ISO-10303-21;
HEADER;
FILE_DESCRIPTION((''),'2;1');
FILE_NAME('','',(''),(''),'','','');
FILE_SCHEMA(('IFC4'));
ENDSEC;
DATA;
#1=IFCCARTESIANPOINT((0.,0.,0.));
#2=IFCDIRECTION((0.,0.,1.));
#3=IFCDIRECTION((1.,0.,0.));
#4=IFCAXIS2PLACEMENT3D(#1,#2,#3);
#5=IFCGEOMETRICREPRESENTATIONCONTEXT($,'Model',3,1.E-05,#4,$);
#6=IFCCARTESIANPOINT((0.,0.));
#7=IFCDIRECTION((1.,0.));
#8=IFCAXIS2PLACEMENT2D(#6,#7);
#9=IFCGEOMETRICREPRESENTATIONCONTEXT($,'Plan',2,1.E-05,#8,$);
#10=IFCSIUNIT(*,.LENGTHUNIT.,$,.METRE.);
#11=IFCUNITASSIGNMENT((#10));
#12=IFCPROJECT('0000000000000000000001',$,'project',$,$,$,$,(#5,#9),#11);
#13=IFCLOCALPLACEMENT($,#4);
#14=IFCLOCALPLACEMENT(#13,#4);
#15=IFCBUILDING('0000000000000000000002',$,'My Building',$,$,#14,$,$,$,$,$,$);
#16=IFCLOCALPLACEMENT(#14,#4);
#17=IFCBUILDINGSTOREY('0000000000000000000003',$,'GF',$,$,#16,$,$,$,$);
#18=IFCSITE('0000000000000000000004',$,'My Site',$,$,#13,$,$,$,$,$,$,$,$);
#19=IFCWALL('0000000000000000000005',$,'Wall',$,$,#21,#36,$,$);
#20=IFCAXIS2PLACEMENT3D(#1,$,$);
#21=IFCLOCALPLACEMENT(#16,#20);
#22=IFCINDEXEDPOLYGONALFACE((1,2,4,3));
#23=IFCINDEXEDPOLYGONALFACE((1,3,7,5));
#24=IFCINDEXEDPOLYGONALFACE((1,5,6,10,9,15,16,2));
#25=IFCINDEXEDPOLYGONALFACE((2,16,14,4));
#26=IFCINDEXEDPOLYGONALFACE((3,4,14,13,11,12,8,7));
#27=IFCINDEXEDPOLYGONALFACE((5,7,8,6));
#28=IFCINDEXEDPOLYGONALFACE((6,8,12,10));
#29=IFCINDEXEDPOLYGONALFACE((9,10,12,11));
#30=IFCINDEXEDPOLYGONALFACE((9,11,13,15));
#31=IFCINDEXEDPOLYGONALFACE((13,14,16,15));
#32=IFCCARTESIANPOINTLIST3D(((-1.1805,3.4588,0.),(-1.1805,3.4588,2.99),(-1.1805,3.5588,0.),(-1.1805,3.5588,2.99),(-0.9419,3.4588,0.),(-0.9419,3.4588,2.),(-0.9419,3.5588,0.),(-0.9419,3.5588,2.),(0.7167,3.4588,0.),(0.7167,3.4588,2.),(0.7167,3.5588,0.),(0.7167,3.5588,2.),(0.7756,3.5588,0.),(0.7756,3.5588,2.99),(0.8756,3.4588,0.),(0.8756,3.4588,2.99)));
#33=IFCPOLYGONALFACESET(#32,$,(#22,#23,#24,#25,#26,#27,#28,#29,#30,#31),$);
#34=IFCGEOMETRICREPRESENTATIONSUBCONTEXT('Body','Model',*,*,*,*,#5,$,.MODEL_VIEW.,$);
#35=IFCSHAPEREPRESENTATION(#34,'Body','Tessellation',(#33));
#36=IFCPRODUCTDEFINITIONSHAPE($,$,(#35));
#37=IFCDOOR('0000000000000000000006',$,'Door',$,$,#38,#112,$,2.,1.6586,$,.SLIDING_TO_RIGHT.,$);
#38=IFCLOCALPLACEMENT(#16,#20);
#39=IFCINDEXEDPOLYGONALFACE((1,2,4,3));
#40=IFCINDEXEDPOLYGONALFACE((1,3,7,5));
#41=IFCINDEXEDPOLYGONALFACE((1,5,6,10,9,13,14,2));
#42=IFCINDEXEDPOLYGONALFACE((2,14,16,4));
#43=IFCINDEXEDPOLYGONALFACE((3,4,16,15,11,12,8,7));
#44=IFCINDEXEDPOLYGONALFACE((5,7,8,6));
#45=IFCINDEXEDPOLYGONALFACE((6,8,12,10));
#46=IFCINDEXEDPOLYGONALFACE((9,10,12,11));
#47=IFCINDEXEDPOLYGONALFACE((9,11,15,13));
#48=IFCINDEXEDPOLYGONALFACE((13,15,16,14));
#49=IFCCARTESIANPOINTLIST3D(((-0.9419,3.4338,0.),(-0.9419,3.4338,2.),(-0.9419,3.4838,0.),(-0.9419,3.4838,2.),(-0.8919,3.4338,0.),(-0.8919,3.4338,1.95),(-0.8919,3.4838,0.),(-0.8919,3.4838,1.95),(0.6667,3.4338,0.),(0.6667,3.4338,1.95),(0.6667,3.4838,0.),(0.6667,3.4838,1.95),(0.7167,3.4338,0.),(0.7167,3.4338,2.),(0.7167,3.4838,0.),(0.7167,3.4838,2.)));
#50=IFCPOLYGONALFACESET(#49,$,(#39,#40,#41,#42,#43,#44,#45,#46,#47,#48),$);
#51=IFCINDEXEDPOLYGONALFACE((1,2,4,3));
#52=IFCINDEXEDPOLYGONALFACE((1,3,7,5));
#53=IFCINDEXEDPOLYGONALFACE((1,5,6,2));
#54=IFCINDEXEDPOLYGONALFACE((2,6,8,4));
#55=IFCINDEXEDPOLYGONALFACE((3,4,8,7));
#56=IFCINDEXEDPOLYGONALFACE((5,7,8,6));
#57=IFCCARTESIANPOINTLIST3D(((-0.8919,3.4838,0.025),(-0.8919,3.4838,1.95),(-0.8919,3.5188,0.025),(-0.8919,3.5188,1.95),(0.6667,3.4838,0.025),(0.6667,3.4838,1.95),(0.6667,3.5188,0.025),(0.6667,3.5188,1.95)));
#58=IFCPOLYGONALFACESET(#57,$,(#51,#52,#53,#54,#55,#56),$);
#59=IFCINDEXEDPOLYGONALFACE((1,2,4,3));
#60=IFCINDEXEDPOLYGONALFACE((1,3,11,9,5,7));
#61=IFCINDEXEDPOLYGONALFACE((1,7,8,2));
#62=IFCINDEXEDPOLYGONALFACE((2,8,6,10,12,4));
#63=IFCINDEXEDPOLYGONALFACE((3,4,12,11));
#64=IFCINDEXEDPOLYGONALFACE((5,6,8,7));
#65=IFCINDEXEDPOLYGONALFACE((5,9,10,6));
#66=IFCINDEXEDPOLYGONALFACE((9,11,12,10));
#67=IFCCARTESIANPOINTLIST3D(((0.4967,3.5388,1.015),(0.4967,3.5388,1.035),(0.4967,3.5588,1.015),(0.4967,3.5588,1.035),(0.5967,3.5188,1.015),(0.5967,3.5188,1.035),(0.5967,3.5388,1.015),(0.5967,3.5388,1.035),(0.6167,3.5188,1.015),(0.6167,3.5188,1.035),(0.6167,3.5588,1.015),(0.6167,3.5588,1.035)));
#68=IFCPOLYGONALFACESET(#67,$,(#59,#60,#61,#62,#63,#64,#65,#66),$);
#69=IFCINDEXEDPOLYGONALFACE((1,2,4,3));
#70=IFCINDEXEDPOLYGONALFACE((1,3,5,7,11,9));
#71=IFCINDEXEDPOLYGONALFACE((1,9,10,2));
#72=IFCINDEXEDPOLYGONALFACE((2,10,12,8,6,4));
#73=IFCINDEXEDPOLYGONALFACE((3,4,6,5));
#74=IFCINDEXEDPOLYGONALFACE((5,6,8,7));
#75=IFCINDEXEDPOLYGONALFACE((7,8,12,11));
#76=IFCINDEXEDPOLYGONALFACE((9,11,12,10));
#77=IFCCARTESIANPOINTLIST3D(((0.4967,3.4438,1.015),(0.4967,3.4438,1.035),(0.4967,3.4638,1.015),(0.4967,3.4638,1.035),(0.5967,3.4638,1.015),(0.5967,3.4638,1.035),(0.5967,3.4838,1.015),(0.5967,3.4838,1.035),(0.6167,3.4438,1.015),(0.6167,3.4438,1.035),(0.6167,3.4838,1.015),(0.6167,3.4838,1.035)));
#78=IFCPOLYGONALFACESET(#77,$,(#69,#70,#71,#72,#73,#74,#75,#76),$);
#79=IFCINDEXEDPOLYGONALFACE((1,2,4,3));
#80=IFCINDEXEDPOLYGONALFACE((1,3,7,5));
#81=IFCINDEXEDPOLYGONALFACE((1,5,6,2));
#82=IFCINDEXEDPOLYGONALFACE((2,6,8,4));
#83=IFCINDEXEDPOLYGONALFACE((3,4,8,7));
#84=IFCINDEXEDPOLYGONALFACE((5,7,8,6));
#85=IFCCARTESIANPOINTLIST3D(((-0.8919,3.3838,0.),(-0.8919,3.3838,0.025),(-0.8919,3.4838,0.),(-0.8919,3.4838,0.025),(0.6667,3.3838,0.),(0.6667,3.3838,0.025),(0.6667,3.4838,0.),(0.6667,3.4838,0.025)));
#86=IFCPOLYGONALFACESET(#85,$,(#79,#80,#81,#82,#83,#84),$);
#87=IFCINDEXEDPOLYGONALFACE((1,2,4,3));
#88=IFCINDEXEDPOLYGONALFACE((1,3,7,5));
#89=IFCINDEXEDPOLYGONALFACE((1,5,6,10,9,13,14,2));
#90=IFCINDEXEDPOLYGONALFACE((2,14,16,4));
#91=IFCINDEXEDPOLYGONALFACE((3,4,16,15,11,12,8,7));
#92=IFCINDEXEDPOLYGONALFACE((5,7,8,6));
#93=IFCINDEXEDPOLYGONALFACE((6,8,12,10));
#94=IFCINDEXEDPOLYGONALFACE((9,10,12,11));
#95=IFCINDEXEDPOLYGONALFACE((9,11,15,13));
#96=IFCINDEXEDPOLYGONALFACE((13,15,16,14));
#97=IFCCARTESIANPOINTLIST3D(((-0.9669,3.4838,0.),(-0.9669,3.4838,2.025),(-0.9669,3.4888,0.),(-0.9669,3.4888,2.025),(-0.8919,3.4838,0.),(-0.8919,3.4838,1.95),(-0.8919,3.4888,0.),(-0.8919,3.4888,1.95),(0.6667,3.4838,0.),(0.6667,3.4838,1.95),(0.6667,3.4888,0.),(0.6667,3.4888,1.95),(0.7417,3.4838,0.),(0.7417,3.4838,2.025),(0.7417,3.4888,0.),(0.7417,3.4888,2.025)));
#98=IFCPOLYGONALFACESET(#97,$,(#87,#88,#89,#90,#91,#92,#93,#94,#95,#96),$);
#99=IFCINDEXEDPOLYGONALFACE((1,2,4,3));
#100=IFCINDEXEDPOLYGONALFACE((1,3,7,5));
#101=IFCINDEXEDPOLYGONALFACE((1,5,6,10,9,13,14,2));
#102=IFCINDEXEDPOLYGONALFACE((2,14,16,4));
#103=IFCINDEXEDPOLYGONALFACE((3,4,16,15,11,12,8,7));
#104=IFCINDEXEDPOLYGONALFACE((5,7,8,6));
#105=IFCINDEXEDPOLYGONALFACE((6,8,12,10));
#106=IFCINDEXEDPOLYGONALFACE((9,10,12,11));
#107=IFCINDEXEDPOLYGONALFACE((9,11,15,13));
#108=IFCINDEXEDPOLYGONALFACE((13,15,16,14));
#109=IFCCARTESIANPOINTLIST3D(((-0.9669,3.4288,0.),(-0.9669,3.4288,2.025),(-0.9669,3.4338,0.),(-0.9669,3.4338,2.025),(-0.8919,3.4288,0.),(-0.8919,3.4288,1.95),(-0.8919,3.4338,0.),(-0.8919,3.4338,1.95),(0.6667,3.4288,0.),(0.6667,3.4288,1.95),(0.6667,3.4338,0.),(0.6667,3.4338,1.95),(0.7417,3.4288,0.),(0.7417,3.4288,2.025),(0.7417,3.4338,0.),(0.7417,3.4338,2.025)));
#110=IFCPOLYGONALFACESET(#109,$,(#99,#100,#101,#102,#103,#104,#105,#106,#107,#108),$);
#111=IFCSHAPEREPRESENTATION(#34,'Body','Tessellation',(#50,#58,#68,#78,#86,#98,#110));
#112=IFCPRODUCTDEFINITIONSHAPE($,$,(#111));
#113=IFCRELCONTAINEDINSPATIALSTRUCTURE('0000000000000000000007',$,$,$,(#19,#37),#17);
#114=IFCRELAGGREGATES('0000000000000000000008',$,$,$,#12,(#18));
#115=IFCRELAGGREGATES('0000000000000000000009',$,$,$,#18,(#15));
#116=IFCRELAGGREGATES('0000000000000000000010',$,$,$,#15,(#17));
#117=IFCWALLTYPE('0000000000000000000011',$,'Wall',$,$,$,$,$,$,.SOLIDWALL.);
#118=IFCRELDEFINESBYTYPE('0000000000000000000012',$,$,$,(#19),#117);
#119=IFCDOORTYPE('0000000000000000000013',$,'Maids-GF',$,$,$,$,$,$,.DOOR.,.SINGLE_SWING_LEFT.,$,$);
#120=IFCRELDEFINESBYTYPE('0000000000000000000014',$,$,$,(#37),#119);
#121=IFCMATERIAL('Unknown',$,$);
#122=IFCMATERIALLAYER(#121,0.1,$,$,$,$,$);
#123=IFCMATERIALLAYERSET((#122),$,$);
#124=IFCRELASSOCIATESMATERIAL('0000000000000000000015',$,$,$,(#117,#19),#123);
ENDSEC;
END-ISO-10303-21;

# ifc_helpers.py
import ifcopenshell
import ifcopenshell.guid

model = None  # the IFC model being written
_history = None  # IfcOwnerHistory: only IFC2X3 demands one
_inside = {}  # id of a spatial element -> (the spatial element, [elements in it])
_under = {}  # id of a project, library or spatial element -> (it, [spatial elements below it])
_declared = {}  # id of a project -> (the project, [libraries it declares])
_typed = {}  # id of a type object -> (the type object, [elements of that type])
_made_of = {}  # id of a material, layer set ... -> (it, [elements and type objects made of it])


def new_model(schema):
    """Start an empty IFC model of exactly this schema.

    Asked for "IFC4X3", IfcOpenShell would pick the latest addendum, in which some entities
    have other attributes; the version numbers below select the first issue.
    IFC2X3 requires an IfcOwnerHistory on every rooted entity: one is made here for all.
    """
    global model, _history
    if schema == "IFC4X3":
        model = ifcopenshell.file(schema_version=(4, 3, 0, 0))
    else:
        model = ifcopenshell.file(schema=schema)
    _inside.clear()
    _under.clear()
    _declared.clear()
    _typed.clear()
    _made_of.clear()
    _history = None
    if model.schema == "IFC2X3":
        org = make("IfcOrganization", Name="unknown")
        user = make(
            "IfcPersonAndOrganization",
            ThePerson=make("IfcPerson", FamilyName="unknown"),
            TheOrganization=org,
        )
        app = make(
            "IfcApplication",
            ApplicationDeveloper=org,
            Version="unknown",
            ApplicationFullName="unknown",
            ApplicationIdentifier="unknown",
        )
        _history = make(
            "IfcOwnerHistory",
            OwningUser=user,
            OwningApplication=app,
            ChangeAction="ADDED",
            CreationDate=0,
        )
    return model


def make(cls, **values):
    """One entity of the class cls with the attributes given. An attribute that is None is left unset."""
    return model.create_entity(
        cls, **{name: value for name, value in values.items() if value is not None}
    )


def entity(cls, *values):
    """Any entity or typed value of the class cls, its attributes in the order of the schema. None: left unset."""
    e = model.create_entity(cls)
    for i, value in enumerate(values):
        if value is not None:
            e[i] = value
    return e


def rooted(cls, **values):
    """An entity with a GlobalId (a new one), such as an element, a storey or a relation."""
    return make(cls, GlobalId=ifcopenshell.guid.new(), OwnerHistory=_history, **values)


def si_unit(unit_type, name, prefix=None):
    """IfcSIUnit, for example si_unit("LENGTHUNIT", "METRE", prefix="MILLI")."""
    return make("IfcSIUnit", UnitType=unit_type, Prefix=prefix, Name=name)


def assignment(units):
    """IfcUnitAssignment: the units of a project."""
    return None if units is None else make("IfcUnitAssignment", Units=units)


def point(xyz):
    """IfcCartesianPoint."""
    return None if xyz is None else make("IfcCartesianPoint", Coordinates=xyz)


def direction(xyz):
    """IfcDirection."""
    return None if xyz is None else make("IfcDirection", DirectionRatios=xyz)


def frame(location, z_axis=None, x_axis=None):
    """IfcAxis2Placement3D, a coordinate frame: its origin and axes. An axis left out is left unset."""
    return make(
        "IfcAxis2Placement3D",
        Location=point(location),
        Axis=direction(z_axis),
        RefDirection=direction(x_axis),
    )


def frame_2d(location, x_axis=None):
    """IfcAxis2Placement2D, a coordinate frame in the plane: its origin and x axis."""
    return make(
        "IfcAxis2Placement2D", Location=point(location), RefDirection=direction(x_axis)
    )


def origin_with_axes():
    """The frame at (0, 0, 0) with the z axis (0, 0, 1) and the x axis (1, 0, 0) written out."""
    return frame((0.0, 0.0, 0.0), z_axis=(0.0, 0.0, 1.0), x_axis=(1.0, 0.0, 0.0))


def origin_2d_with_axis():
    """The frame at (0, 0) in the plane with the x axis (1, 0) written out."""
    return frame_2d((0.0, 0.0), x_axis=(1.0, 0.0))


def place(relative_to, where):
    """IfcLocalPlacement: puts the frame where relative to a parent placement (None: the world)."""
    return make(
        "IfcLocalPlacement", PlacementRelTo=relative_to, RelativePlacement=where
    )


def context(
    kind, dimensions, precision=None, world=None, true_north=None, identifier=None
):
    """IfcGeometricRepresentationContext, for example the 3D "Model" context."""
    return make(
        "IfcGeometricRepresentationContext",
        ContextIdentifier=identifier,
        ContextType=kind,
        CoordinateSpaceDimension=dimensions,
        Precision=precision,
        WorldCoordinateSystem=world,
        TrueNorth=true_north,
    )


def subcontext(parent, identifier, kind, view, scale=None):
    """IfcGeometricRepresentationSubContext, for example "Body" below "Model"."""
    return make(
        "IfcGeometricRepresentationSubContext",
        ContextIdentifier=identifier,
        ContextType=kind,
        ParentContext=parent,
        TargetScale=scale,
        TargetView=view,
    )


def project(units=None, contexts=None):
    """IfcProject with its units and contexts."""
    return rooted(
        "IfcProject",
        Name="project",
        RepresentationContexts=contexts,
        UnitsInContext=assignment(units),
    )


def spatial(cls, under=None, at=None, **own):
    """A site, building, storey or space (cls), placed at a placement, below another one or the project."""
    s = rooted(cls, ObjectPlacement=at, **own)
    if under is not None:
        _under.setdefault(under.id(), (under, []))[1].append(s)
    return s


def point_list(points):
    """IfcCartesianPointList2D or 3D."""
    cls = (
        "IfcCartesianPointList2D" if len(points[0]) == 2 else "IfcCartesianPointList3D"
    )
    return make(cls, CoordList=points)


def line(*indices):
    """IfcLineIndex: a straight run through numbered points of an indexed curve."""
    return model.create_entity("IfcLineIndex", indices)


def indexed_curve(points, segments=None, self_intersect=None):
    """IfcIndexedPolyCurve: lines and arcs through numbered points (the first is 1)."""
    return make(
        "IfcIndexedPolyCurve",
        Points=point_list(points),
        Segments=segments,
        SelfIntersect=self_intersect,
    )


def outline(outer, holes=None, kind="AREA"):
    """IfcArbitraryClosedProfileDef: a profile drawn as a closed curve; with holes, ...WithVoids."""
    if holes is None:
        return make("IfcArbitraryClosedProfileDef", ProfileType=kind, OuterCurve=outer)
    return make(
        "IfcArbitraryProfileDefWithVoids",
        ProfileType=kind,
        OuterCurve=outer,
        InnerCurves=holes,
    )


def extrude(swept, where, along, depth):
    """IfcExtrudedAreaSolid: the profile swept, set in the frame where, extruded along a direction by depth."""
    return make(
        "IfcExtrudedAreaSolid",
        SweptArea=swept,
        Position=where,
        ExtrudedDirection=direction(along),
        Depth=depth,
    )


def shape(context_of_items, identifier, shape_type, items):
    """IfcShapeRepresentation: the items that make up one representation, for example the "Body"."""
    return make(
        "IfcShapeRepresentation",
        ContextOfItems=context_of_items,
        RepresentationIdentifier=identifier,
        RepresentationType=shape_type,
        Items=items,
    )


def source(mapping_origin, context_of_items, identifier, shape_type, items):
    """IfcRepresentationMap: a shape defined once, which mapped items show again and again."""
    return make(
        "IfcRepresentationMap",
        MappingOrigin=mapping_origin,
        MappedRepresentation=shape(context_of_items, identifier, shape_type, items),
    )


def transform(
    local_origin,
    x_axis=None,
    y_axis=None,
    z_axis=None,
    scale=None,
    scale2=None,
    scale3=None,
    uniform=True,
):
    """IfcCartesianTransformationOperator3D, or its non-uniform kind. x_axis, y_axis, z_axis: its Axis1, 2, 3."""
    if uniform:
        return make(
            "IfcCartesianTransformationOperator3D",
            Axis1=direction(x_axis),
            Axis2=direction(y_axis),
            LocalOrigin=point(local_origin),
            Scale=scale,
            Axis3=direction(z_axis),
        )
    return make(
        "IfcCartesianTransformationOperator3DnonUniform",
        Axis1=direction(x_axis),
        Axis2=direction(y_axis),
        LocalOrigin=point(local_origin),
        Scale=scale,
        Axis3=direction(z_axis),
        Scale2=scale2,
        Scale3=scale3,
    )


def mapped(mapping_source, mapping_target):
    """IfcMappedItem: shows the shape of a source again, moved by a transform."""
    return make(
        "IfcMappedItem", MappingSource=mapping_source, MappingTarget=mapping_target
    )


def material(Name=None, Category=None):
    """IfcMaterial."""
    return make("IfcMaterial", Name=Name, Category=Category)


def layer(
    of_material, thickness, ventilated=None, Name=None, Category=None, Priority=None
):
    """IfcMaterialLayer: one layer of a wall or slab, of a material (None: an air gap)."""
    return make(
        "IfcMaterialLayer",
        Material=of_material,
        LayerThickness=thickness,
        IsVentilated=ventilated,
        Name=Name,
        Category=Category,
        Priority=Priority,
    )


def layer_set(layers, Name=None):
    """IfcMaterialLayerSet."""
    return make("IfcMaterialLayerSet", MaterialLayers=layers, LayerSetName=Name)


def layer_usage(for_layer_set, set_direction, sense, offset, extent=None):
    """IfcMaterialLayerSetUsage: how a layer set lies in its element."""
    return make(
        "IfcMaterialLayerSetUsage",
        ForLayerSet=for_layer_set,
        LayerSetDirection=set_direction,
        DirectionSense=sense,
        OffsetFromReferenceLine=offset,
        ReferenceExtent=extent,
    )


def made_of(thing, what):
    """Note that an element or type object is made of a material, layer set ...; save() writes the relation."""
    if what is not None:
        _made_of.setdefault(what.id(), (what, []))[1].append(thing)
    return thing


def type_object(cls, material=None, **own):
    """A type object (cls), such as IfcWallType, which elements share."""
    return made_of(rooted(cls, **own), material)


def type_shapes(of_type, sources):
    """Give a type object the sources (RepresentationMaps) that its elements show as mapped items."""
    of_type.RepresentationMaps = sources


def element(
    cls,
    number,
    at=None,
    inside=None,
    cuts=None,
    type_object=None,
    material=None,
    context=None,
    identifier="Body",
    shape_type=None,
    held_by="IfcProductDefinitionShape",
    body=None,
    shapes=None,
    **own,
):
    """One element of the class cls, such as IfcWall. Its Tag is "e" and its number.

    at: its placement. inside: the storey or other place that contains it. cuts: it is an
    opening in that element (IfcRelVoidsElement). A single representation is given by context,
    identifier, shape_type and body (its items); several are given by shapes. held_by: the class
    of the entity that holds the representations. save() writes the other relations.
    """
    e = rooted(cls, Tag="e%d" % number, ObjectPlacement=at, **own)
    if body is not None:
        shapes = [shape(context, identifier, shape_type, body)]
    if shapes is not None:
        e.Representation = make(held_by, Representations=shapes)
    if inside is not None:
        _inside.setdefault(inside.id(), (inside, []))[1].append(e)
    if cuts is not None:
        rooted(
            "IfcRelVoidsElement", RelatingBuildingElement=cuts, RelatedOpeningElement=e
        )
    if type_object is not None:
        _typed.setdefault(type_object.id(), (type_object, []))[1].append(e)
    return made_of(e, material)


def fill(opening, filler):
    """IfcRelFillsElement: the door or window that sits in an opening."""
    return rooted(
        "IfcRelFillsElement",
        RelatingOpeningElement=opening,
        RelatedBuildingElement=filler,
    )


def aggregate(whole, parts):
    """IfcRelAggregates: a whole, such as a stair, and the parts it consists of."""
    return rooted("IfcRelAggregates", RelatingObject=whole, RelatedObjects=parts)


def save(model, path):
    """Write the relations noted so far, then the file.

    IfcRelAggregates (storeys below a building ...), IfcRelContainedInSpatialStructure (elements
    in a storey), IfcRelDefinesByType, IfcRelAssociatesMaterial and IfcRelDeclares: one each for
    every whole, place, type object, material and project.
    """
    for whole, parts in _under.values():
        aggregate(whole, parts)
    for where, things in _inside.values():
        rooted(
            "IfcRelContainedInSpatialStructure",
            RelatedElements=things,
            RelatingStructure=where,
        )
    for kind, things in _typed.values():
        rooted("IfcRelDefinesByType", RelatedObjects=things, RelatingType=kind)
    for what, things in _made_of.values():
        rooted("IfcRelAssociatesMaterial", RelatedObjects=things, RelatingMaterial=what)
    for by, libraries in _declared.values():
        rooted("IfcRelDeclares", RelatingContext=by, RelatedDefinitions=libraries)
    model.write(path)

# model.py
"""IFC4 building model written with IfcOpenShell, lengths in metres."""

from ifc_helpers import new_model, entity, si_unit, frame, origin_with_axes, origin_2d_with_axis, place, context, subcontext, project, spatial, line, indexed_curve, outline, extrude, shape, source, transform, mapped, material, layer, layer_set, layer_usage, type_object, type_shapes, element, fill, save


model = new_model("IFC4")

# Units and contexts
model_context = context("Model", 3, precision=1e-05, world=origin_with_axes())
plan_context = context("Plan", 2, precision=1e-05, world=origin_2d_with_axis())
body_context_1 = subcontext(model_context, "Body", "Model", "MODEL_VIEW")
body_context_2 = subcontext(plan_context, "Body", "Plan", "PLAN_VIEW")
ifc_project = project(units=[si_unit("LENGTHUNIT", "METRE")], contexts=[model_context, plan_context])

# Site, building, storey
site_placement = place(None, origin_with_axes())
site = spatial("IfcSite", under=ifc_project, at=site_placement, Name="My Site")
building_placement = place(site_placement, origin_with_axes())
building = spatial("IfcBuilding", under=site, at=building_placement, Name="My Building")
storey_placement = place(building_placement, origin_with_axes())
storey = spatial("IfcBuildingStorey", under=building, at=storey_placement, Name="GF")

# Shared definitions
ifc_material = material(Name="Unknown")

# Shared definitions
ifc_layer_1 = layer(ifc_material, 0.1)
ifc_layer_set_1 = layer_set([ifc_layer_1])
wall_type = type_object("IfcWallType", Name="Wall", PredefinedType="SOLIDWALL", material=ifc_layer_set_1)

# Wall, opening, door
ifc_layer_usage_1 = layer_usage(ifc_layer_set_1, "AXIS2", "POSITIVE", 0.0)
wall_1_placement = place(storey_placement, frame((0.7756, 3.5588, 0.0), z_axis=(0.0, 0.0, 1.0), x_axis=(-1.0, 0.0, 0.0)))
wall_1 = element("IfcWall", 1, at=wall_1_placement, inside=storey, type_object=wall_type, material=ifc_layer_usage_1, Name="Wall", context=body_context_1, shape_type="SweptSolid", body=[
    extrude(outline(indexed_curve([(0.0, 0.0), (-0.1, 0.1), (1.9562, 0.1), (1.9562, 0.0)], segments=[line(1, 2, 3, 4, 1)])), origin_with_axes(), (0.0, 0.0, 1.0), 2.99),
])
shared_shape_1 = source(origin_with_axes(), body_context_1, "Body", "SweptSolid", [
    extrude(outline(indexed_curve([(0.0, 0.0), (1.6586, 0.0), (1.6586, 2.0), (0.0, 2.0)], segments=[line(1, 2, 3, 4, 1)])), frame((0.0, -0.6, 0.0), z_axis=(0.0, -1.0, 0.0), x_axis=(1.0, 0.0, 0.0)), (0.0, 0.0, -1.0), 1.2),
])
opening_1_placement = place(wall_1_placement, frame((0.0589, 0.075, 0.0), z_axis=(0.0, 0.0, 1.0), x_axis=(1.0, 0.0, 0.0)))
opening_1 = element("IfcOpeningElement", 2, at=opening_1_placement, cuts=wall_1, PredefinedType="OPENING", context=body_context_1, shape_type="MappedRepresentation", body=[
    mapped(shared_shape_1, transform((0.0, 0.0, 0.0), x_axis=(1.0, 0.0, 0.0), y_axis=(0.0, 1.0, 0.0), z_axis=(0.0, 0.0, 1.0), scale=1.0)),
])
door_type_1 = type_object("IfcDoorType", Name="Maids-GF", OperationType="SINGLE_SWING_LEFT", PredefinedType="DOOR")
shared_shape_2 = source(origin_with_axes(), body_context_1, "Body", "SweptSolid", [
    extrude(outline(indexed_curve([(0.0, 0.0), (0.0, 2.0), (1.6586, 2.0), (1.6586, 0.0), (1.6086, 0.0), (1.6086, 1.95), (0.05, 1.95), (0.05, 0.0)], segments=[line(1, 2, 3, 4, 5, 6, 7, 8, 1)])), frame((0.0, 0.0, 0.0), z_axis=(0.0, -1.0, 0.0), x_axis=(1.0, 0.0, 0.0)), (0.0, 0.0, -1.0), 0.05),
    extrude(outline(indexed_curve([(0.0, 0.0), (1.5586, 0.0), (1.5586, 0.035), (0.0, 0.035)], segments=[line(1, 2, 3, 4, 1)])), frame((0.05, -0.035, 0.025), z_axis=(0.0, 0.0, 1.0), x_axis=(1.0, 0.0, 0.0)), (0.0, 0.0, 1.0), 1.925),
    extrude(outline(indexed_curve([(0.0, 0.0), (0.0, -0.04), (0.12, -0.04), (0.12, -0.02), (0.02, -0.02), (0.02, 0.0)], segments=[line(1, 2, 3, 4, 5, 6, 1)])), frame((0.1, -0.035, 1.015), z_axis=(0.0, 0.0, 1.0), x_axis=(1.0, 0.0, 0.0)), (0.0, 0.0, 1.0), 0.02),
    extrude(outline(indexed_curve([(0.0, 0.0), (0.0, 0.04), (0.12, 0.04), (0.12, 0.02), (0.02, 0.02), (0.02, 0.0)], segments=[line(1, 2, 3, 4, 5, 6, 1)])), frame((0.1, 0.0, 1.015), z_axis=(0.0, 0.0, 1.0), x_axis=(1.0, 0.0, 0.0)), (0.0, 0.0, 1.0), 0.02),
    extrude(outline(indexed_curve([(0.0, 0.0), (1.5586, 0.0), (1.5586, 0.1), (0.0, 0.1)], segments=[line(1, 2, 3, 4, 1)])), frame((0.05, 0.0, 0.0), z_axis=(0.0, 0.0, 1.0), x_axis=(1.0, 0.0, 0.0)), (0.0, 0.0, 1.0), 0.025),
    extrude(outline(indexed_curve([(0.0, 0.0), (0.0, 2.025), (1.7086, 2.025), (1.7086, 0.0), (1.6336, 0.0), (1.6336, 1.95), (0.075, 1.95), (0.075, 0.0)], segments=[line(1, 2, 3, 4, 5, 6, 7, 8, 1)])), frame((-0.025, -0.005, 0.0), z_axis=(0.0, -1.0, 0.0), x_axis=(1.0, 0.0, 0.0)), (0.0, 0.0, -1.0), 0.005),
    extrude(outline(indexed_curve([(0.0, 0.0), (0.0, 2.025), (1.7086, 2.025), (1.7086, 0.0), (1.6336, 0.0), (1.6336, 1.95), (0.075, 1.95), (0.075, 0.0)], segments=[line(1, 2, 3, 4, 5, 6, 7, 8, 1)])), frame((-0.025, 0.05, 0.0), z_axis=(0.0, -1.0, 0.0), x_axis=(1.0, 0.0, 0.0)), (0.0, 0.0, -1.0), 0.005),
])
shared_shape_3 = source(origin_with_axes(), body_context_2, "Body", "Curve2D", [
    entity("IfcIndexedPolyCurve", entity("IfcCartesianPointList2D", [[0.0, 0.0], [0.05, 0.0], [0.05, 0.05], [0.0, 0.05]]), [entity("IfcLineIndex", [1, 2, 3, 4, 1])]),
    entity("IfcIndexedPolyCurve", entity("IfcCartesianPointList2D", [[1.6586, 0.0], [1.6086, 0.0], [1.6086, 0.05], [1.6586, 0.05]]), [entity("IfcLineIndex", [1, 2, 3, 4, 1])]),
    entity("IfcIndexedPolyCurve", entity("IfcCartesianPointList2D", [[2.3879, -0.035], [0.8293, -0.035], [0.8293, 0.0], [2.3879, 0.0]]), [entity("IfcLineIndex", [1, 2, 3, 4, 1])]),
])
type_shapes(door_type_1, [shared_shape_2, shared_shape_3])
door_1_placement = place(opening_1_placement, frame((0.0, 0.0, 0.0), z_axis=(0.0, 0.0, 1.0), x_axis=(1.0, 0.0, 0.0)))
door_1 = element("IfcDoor", 3, at=door_1_placement, inside=storey, type_object=door_type_1, Name="Door", OperationType="SLIDING_TO_RIGHT", OverallHeight=2.0, OverallWidth=1.6586, shapes=[
    shape(body_context_1, "Body", "MappedRepresentation", [mapped(shared_shape_2, transform((0.0, 0.0, 0.0), x_axis=(1.0, 0.0, 0.0), y_axis=(0.0, 1.0, 0.0), z_axis=(0.0, 0.0, 1.0), scale=1.0))]),
    shape(body_context_2, "Body", "MappedRepresentation", [mapped(shared_shape_3, transform((0.0, 0.0, 0.0), x_axis=(1.0, 0.0, 0.0), y_axis=(0.0, 1.0, 0.0), z_axis=(0.0, 0.0, 1.0), scale=1.0))]),
])
fill(opening_1, door_1)

save(model, "model.ifc")
